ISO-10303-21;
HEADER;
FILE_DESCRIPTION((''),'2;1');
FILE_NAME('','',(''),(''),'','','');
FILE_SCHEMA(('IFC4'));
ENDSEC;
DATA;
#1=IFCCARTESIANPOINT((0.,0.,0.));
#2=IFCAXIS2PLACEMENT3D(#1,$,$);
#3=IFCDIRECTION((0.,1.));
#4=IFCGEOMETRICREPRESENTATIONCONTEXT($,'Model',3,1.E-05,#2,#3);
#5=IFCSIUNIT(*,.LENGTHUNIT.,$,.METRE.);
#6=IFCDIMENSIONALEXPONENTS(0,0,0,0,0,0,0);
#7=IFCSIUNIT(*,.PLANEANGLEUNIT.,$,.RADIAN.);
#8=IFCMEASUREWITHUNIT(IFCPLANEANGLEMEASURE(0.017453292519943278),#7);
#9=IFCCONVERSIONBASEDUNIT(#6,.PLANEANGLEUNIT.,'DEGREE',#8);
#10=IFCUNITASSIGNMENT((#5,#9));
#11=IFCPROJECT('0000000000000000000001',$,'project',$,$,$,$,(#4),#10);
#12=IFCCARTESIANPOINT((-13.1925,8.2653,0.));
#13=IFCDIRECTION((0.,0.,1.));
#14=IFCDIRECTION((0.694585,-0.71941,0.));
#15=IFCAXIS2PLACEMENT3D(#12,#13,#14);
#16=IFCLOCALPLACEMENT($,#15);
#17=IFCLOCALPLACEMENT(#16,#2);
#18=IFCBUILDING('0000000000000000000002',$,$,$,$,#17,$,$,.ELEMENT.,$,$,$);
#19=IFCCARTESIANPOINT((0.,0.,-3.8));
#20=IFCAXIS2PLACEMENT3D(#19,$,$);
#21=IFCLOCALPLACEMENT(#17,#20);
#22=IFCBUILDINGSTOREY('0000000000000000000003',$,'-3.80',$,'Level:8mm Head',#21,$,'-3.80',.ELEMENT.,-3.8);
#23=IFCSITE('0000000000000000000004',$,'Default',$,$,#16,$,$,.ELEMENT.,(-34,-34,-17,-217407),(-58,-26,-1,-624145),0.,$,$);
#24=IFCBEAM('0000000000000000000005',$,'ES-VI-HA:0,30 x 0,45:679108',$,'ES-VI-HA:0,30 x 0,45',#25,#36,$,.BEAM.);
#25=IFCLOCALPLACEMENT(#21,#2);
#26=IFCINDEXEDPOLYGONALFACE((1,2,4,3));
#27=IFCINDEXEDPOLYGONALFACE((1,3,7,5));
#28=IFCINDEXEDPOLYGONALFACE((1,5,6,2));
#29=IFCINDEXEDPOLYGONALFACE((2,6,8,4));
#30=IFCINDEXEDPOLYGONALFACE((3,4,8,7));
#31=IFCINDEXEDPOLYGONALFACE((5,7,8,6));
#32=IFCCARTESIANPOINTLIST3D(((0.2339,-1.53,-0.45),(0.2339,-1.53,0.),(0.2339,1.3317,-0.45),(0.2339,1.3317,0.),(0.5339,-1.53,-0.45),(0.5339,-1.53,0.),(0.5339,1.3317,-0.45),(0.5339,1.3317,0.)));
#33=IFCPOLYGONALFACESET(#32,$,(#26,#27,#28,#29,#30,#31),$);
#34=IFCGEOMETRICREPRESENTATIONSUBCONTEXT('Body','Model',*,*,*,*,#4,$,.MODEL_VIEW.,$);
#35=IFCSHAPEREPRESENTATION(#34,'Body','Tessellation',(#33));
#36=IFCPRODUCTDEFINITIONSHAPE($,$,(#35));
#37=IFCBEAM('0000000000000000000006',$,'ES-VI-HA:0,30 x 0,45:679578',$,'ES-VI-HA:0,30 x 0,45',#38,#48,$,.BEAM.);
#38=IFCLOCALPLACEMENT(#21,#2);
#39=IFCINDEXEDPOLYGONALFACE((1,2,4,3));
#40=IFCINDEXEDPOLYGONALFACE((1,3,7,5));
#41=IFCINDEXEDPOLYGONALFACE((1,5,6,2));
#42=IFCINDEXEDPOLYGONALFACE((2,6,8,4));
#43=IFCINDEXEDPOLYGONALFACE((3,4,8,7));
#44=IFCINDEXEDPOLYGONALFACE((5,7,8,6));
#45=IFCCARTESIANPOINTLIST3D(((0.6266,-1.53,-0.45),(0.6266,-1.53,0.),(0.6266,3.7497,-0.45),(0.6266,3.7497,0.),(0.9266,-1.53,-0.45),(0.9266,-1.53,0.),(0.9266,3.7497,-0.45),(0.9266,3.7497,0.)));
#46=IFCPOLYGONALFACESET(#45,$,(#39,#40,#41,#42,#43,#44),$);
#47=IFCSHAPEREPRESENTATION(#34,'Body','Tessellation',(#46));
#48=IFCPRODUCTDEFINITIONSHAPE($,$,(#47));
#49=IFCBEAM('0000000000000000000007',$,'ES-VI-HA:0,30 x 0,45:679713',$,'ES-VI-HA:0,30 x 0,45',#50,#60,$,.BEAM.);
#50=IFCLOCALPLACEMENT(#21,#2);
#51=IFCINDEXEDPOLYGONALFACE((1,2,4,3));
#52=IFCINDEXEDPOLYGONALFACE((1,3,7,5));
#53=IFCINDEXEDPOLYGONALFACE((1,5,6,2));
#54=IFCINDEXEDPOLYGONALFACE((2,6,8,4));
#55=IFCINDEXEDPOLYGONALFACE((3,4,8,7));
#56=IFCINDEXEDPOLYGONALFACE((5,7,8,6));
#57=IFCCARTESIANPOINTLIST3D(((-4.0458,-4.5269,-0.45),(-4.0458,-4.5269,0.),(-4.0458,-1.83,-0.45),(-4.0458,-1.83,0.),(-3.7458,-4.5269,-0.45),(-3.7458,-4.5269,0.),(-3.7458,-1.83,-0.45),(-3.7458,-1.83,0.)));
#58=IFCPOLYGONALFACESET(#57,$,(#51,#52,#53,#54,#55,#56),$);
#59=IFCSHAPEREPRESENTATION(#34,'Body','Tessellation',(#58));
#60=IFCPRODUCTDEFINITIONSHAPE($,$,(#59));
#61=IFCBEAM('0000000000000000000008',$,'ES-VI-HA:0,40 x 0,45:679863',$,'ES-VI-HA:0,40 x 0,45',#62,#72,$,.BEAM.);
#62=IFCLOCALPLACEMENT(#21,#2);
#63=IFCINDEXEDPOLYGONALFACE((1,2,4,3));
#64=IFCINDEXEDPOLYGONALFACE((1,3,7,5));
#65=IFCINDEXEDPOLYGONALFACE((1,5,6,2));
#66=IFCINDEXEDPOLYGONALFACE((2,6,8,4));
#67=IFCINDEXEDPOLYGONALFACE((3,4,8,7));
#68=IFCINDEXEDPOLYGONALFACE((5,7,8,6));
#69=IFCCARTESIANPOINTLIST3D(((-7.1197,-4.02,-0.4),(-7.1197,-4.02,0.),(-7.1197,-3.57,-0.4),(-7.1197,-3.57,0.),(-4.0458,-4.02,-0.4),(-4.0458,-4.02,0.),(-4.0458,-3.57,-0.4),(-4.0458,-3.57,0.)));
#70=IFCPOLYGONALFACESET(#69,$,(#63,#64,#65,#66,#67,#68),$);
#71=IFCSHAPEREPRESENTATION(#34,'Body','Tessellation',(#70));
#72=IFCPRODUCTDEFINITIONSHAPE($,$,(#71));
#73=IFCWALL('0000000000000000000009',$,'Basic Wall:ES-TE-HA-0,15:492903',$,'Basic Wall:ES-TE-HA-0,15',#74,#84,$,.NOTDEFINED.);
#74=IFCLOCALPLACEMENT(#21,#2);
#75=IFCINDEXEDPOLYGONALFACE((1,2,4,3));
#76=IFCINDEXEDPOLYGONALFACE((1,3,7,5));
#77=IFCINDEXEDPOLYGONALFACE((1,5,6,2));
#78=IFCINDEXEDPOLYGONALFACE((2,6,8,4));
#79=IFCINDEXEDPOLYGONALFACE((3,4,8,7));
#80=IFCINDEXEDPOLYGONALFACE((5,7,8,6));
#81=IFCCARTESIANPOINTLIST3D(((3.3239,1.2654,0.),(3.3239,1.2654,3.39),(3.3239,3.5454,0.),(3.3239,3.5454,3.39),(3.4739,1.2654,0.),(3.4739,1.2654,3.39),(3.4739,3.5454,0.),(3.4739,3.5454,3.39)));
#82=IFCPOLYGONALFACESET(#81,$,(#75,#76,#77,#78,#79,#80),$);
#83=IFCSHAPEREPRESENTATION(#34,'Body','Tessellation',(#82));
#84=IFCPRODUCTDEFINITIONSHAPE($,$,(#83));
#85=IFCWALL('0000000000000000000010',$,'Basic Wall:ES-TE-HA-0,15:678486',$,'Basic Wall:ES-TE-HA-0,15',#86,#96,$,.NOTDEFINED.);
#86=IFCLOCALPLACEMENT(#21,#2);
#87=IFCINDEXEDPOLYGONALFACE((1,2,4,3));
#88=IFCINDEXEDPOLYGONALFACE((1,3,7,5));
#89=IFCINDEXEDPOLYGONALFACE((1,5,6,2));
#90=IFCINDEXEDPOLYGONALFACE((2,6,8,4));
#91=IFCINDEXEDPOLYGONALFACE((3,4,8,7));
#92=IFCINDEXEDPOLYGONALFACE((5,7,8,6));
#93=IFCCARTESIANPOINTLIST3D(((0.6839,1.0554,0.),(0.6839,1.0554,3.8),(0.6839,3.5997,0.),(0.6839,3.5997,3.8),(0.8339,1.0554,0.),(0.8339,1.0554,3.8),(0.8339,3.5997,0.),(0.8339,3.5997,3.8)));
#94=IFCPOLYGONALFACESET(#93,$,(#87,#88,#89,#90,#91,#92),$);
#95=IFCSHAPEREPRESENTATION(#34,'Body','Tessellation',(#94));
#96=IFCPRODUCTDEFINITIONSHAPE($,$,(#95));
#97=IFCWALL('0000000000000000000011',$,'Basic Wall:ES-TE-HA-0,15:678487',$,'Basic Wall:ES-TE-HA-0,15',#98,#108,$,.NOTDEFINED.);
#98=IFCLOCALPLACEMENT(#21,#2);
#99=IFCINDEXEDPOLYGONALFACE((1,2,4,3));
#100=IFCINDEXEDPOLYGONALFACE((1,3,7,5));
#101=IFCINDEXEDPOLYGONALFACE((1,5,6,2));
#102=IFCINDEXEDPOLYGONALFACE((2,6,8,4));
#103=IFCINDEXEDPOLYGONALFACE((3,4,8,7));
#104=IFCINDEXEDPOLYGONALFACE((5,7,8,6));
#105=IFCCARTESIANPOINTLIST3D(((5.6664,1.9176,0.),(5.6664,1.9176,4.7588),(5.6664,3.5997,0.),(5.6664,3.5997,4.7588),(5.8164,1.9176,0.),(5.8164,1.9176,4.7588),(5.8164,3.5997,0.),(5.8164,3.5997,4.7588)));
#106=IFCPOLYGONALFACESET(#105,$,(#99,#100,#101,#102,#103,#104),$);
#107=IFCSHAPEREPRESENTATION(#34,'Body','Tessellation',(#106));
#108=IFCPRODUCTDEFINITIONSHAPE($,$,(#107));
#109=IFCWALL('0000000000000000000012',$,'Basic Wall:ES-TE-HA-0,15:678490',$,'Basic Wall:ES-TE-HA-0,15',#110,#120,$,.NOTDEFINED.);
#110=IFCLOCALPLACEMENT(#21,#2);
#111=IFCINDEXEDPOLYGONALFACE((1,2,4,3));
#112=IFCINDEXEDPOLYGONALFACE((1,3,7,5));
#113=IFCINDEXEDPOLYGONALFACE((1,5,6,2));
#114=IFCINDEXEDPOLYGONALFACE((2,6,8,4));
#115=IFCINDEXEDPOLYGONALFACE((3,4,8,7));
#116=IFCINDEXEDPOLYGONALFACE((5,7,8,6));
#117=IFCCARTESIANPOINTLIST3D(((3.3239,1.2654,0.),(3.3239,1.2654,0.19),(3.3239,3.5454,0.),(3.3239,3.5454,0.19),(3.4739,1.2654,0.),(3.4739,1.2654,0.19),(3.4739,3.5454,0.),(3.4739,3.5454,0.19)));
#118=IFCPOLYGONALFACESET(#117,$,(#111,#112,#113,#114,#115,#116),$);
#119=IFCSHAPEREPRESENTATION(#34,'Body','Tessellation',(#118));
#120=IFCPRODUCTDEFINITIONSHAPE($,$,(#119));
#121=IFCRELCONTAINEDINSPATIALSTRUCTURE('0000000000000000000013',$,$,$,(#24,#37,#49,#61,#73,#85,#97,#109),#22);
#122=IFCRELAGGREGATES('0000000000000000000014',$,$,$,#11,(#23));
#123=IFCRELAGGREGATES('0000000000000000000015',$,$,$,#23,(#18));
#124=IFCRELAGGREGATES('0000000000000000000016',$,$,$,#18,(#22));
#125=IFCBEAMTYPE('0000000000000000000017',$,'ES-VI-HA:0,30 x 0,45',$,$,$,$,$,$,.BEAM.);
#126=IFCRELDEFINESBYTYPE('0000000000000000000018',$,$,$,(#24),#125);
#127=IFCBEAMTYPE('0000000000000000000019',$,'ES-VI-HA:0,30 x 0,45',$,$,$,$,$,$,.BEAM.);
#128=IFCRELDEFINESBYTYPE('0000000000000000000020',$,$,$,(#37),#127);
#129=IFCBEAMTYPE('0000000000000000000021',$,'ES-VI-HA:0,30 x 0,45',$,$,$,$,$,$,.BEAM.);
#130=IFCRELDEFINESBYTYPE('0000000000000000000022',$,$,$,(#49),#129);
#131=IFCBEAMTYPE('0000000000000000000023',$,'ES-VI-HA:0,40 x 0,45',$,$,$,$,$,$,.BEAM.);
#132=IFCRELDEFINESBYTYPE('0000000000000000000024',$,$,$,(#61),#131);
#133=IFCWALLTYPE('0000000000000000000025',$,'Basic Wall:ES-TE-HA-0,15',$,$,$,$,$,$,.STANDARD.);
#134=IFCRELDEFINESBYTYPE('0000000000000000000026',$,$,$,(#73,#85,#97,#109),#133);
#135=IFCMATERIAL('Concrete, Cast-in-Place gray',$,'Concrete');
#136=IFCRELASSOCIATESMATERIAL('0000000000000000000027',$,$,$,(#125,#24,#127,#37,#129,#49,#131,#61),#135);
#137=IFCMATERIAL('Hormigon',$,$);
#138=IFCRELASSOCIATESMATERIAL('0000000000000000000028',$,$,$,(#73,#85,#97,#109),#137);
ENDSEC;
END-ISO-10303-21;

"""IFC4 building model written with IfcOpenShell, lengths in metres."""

from ifc_helpers import new_model, entity, si_unit, converted_unit, direction, frame, origin, place, context, subcontext, project, spatial, indexed_curve, outline, extrude, source, transform, mapped, material, type_object, type_shapes, element, save


model = new_model("IFC4")

# Units and contexts
model_context = context("Model", 3, precision=1e-05, world=origin(), true_north=direction((0.0, 1.0)))
body_context = subcontext(model_context, "Body", "Model", "MODEL_VIEW")
ifc_project = project(units=[si_unit("LENGTHUNIT", "METRE"), converted_unit("PLANEANGLEUNIT", "DEGREE", entity("IfcPlaneAngleMeasure", 0.017453292519943278), si_unit("PLANEANGLEUNIT", "RADIAN"), dimensions=[0, 0, 0, 0, 0, 0, 0])], contexts=[model_context])

# Site, building, storey
site_placement = place(None, frame((-13.1925, 8.2653, 0.0), z_axis=(0.0, 0.0, 1.0), x_axis=(0.694585, -0.71941, 0.0)))
site = spatial("IfcSite", under=ifc_project, at=site_placement, Name="Default", CompositionType="ELEMENT", RefLatitude=(-34, -34, -17, -217407), RefLongitude=(-58, -26, -1, -624145), RefElevation=0.0)
building_placement = place(site_placement, origin())
building = spatial("IfcBuilding", under=site, at=building_placement, CompositionType="ELEMENT")
storey_placement = place(building_placement, frame((0.0, 0.0, -3.8)))
storey = spatial("IfcBuildingStorey", under=building, at=storey_placement, Name="-3.80", ObjectType="Level:8mm Head", LongName="-3.80", CompositionType="ELEMENT", Elevation=-3.8)

# Beams
ifc_material_1 = material(Name="Concrete, Cast-in-Place gray", Category="Concrete")
beam_type_1 = type_object("IfcBeamType", Name="ES-VI-HA:0,30 x 0,45", PredefinedType="BEAM", material=ifc_material_1)
shared_shape_1 = source(origin(), body_context, "Body", "SweptSolid", [
    extrude(outline(indexed_curve([(-0.15, -0.225), (0.15, -0.225), (0.15, 0.225), (-0.15, 0.225), (-0.15, -0.225)], self_intersect=False)), frame((0.3839, -1.53, -4.025), z_axis=(0.0, 1.0, 0.0), x_axis=(-1.0, 0.0, 0.0)), (0.0, 0.0, 1.0), 2.8617),
])
type_shapes(beam_type_1, [shared_shape_1])
beam_1_placement = place(storey_placement, frame((0.0, 0.0, 3.8)))
element("IfcBeam", 1, at=beam_1_placement, inside=storey, type_object=beam_type_1, material=ifc_material_1, Name="ES-VI-HA:0,30 x 0,45:679108", ObjectType="ES-VI-HA:0,30 x 0,45", PredefinedType="BEAM", context=body_context, shape_type="MappedRepresentation", body=[
    mapped(shared_shape_1, transform((0.0, 0.0, 0.0), scale=1.0)),
])
beam_type_2 = type_object("IfcBeamType", Name="ES-VI-HA:0,30 x 0,45", PredefinedType="BEAM", material=ifc_material_1)
shared_shape_2 = source(origin(), body_context, "Body", "SweptSolid", [
    extrude(outline(indexed_curve([(-0.15, -0.225), (0.15, -0.225), (0.15, 0.225), (-0.15, 0.225), (-0.15, -0.225)], self_intersect=False)), frame((0.7766, -1.53, -4.025), z_axis=(0.0, 1.0, 0.0), x_axis=(-1.0, 0.0, 0.0)), (0.0, 0.0, 1.0), 5.2797),
])
type_shapes(beam_type_2, [shared_shape_2])
beam_2_placement = place(storey_placement, frame((0.0, 0.0, 3.8)))
element("IfcBeam", 2, at=beam_2_placement, inside=storey, type_object=beam_type_2, material=ifc_material_1, Name="ES-VI-HA:0,30 x 0,45:679578", ObjectType="ES-VI-HA:0,30 x 0,45", PredefinedType="BEAM", context=body_context, shape_type="MappedRepresentation", body=[
    mapped(shared_shape_2, transform((0.0, 0.0, 0.0), scale=1.0)),
])
beam_type_3 = type_object("IfcBeamType", Name="ES-VI-HA:0,30 x 0,45", PredefinedType="BEAM", material=ifc_material_1)
shared_shape_3 = source(origin(), body_context, "Body", "SweptSolid", [
    extrude(outline(indexed_curve([(-0.15, -0.225), (0.15, -0.225), (0.15, 0.225), (-0.15, 0.225), (-0.15, -0.225)], self_intersect=False)), frame((-3.8958, -4.5269, -4.025), z_axis=(0.0, 1.0, 0.0), x_axis=(-1.0, 0.0, 0.0)), (0.0, 0.0, 1.0), 2.6969),
])
type_shapes(beam_type_3, [shared_shape_3])
beam_3_placement = place(storey_placement, frame((0.0, 0.0, 3.8)))
element("IfcBeam", 3, at=beam_3_placement, inside=storey, type_object=beam_type_3, material=ifc_material_1, Name="ES-VI-HA:0,30 x 0,45:679713", ObjectType="ES-VI-HA:0,30 x 0,45", PredefinedType="BEAM", context=body_context, shape_type="MappedRepresentation", body=[
    mapped(shared_shape_3, transform((0.0, 0.0, 0.0), scale=1.0)),
])
beam_type_4 = type_object("IfcBeamType", Name="ES-VI-HA:0,40 x 0,45", PredefinedType="BEAM", material=ifc_material_1)
shared_shape_4 = source(origin(), body_context, "Body", "SweptSolid", [
    extrude(outline(indexed_curve([(-0.2, -0.225), (0.2, -0.225), (0.2, 0.225), (-0.2, 0.225), (-0.2, -0.225)], self_intersect=False)), frame((-7.1197, -3.795, -4.0), z_axis=(1.0, 0.0, 0.0), x_axis=(0.0, 0.0, -1.0)), (0.0, 0.0, 1.0), 3.0739),
])
type_shapes(beam_type_4, [shared_shape_4])
beam_4_placement = place(storey_placement, frame((0.0, 0.0, 3.8)))
element("IfcBeam", 4, at=beam_4_placement, inside=storey, type_object=beam_type_4, material=ifc_material_1, Name="ES-VI-HA:0,40 x 0,45:679863", ObjectType="ES-VI-HA:0,40 x 0,45", PredefinedType="BEAM", context=body_context, shape_type="MappedRepresentation", body=[
    mapped(shared_shape_4, transform((0.0, 0.0, 0.0), scale=1.0)),
])

# Walls
ifc_material_2 = material(Name="Hormigon")
wall_type = type_object("IfcWallType", Name="Basic Wall:ES-TE-HA-0,15", PredefinedType="STANDARD")
wall_1_placement = place(storey_placement, frame((3.3989, 1.2654, 0.0), z_axis=(0.0, 0.0, 1.0), x_axis=(0.0, 1.0, 0.0)))
element("IfcWall", 5, at=wall_1_placement, inside=storey, type_object=wall_type, material=ifc_material_2, Name="Basic Wall:ES-TE-HA-0,15:492903", ObjectType="Basic Wall:ES-TE-HA-0,15", PredefinedType="NOTDEFINED", context=body_context, shape_type="SweptSolid", body=[
    extrude(outline(indexed_curve([(2.2801, 0.075), (0.0, 0.075), (0.0, -0.075), (2.2801, -0.075), (2.2801, 0.075)], self_intersect=False)), origin(), (0.0, 0.0, 1.0), 3.39),
])
wall_2_placement = place(storey_placement, frame((0.7589, 1.0554, 0.0), z_axis=(0.0, 0.0, 1.0), x_axis=(0.0, 1.0, 0.0)))
element("IfcWall", 6, at=wall_2_placement, inside=storey, type_object=wall_type, material=ifc_material_2, Name="Basic Wall:ES-TE-HA-0,15:678486", ObjectType="Basic Wall:ES-TE-HA-0,15", PredefinedType="NOTDEFINED", context=body_context, shape_type="SweptSolid", body=[
    extrude(outline(indexed_curve([(2.5442, 0.075), (0.0, 0.075), (0.0, -0.075), (2.5442, -0.075), (2.5442, 0.075)], self_intersect=False)), origin(), (0.0, 0.0, 1.0), 3.8),
])
wall_3_placement = place(storey_placement, frame((5.7414, 1.9176, 0.0), z_axis=(0.0, 0.0, 1.0), x_axis=(0.0, 1.0, 0.0)))
element("IfcWall", 7, at=wall_3_placement, inside=storey, type_object=wall_type, material=ifc_material_2, Name="Basic Wall:ES-TE-HA-0,15:678487", ObjectType="Basic Wall:ES-TE-HA-0,15", PredefinedType="NOTDEFINED", context=body_context, shape_type="SweptSolid", body=[
    extrude(outline(indexed_curve([(1.682, 0.075), (0.0, 0.075), (0.0, -0.075), (1.682, -0.075), (1.682, 0.075)], self_intersect=False)), origin(), (0.0, 0.0, 1.0), 4.7588),
])
wall_4_placement = place(storey_placement, frame((3.3989, 1.2654, 0.0), z_axis=(0.0, 0.0, 1.0), x_axis=(0.0, 1.0, 0.0)))
element("IfcWall", 8, at=wall_4_placement, inside=storey, type_object=wall_type, material=ifc_material_2, Name="Basic Wall:ES-TE-HA-0,15:678490", ObjectType="Basic Wall:ES-TE-HA-0,15", PredefinedType="NOTDEFINED", context=body_context, shape_type="SweptSolid", body=[
    extrude(outline(indexed_curve([(2.2801, 0.075), (0.0, 0.075), (0.0, -0.075), (2.2801, -0.075), (2.2801, 0.075)], self_intersect=False)), origin(), (0.0, 0.0, 1.0), 0.19),
])

save(model, "model.ifc")
